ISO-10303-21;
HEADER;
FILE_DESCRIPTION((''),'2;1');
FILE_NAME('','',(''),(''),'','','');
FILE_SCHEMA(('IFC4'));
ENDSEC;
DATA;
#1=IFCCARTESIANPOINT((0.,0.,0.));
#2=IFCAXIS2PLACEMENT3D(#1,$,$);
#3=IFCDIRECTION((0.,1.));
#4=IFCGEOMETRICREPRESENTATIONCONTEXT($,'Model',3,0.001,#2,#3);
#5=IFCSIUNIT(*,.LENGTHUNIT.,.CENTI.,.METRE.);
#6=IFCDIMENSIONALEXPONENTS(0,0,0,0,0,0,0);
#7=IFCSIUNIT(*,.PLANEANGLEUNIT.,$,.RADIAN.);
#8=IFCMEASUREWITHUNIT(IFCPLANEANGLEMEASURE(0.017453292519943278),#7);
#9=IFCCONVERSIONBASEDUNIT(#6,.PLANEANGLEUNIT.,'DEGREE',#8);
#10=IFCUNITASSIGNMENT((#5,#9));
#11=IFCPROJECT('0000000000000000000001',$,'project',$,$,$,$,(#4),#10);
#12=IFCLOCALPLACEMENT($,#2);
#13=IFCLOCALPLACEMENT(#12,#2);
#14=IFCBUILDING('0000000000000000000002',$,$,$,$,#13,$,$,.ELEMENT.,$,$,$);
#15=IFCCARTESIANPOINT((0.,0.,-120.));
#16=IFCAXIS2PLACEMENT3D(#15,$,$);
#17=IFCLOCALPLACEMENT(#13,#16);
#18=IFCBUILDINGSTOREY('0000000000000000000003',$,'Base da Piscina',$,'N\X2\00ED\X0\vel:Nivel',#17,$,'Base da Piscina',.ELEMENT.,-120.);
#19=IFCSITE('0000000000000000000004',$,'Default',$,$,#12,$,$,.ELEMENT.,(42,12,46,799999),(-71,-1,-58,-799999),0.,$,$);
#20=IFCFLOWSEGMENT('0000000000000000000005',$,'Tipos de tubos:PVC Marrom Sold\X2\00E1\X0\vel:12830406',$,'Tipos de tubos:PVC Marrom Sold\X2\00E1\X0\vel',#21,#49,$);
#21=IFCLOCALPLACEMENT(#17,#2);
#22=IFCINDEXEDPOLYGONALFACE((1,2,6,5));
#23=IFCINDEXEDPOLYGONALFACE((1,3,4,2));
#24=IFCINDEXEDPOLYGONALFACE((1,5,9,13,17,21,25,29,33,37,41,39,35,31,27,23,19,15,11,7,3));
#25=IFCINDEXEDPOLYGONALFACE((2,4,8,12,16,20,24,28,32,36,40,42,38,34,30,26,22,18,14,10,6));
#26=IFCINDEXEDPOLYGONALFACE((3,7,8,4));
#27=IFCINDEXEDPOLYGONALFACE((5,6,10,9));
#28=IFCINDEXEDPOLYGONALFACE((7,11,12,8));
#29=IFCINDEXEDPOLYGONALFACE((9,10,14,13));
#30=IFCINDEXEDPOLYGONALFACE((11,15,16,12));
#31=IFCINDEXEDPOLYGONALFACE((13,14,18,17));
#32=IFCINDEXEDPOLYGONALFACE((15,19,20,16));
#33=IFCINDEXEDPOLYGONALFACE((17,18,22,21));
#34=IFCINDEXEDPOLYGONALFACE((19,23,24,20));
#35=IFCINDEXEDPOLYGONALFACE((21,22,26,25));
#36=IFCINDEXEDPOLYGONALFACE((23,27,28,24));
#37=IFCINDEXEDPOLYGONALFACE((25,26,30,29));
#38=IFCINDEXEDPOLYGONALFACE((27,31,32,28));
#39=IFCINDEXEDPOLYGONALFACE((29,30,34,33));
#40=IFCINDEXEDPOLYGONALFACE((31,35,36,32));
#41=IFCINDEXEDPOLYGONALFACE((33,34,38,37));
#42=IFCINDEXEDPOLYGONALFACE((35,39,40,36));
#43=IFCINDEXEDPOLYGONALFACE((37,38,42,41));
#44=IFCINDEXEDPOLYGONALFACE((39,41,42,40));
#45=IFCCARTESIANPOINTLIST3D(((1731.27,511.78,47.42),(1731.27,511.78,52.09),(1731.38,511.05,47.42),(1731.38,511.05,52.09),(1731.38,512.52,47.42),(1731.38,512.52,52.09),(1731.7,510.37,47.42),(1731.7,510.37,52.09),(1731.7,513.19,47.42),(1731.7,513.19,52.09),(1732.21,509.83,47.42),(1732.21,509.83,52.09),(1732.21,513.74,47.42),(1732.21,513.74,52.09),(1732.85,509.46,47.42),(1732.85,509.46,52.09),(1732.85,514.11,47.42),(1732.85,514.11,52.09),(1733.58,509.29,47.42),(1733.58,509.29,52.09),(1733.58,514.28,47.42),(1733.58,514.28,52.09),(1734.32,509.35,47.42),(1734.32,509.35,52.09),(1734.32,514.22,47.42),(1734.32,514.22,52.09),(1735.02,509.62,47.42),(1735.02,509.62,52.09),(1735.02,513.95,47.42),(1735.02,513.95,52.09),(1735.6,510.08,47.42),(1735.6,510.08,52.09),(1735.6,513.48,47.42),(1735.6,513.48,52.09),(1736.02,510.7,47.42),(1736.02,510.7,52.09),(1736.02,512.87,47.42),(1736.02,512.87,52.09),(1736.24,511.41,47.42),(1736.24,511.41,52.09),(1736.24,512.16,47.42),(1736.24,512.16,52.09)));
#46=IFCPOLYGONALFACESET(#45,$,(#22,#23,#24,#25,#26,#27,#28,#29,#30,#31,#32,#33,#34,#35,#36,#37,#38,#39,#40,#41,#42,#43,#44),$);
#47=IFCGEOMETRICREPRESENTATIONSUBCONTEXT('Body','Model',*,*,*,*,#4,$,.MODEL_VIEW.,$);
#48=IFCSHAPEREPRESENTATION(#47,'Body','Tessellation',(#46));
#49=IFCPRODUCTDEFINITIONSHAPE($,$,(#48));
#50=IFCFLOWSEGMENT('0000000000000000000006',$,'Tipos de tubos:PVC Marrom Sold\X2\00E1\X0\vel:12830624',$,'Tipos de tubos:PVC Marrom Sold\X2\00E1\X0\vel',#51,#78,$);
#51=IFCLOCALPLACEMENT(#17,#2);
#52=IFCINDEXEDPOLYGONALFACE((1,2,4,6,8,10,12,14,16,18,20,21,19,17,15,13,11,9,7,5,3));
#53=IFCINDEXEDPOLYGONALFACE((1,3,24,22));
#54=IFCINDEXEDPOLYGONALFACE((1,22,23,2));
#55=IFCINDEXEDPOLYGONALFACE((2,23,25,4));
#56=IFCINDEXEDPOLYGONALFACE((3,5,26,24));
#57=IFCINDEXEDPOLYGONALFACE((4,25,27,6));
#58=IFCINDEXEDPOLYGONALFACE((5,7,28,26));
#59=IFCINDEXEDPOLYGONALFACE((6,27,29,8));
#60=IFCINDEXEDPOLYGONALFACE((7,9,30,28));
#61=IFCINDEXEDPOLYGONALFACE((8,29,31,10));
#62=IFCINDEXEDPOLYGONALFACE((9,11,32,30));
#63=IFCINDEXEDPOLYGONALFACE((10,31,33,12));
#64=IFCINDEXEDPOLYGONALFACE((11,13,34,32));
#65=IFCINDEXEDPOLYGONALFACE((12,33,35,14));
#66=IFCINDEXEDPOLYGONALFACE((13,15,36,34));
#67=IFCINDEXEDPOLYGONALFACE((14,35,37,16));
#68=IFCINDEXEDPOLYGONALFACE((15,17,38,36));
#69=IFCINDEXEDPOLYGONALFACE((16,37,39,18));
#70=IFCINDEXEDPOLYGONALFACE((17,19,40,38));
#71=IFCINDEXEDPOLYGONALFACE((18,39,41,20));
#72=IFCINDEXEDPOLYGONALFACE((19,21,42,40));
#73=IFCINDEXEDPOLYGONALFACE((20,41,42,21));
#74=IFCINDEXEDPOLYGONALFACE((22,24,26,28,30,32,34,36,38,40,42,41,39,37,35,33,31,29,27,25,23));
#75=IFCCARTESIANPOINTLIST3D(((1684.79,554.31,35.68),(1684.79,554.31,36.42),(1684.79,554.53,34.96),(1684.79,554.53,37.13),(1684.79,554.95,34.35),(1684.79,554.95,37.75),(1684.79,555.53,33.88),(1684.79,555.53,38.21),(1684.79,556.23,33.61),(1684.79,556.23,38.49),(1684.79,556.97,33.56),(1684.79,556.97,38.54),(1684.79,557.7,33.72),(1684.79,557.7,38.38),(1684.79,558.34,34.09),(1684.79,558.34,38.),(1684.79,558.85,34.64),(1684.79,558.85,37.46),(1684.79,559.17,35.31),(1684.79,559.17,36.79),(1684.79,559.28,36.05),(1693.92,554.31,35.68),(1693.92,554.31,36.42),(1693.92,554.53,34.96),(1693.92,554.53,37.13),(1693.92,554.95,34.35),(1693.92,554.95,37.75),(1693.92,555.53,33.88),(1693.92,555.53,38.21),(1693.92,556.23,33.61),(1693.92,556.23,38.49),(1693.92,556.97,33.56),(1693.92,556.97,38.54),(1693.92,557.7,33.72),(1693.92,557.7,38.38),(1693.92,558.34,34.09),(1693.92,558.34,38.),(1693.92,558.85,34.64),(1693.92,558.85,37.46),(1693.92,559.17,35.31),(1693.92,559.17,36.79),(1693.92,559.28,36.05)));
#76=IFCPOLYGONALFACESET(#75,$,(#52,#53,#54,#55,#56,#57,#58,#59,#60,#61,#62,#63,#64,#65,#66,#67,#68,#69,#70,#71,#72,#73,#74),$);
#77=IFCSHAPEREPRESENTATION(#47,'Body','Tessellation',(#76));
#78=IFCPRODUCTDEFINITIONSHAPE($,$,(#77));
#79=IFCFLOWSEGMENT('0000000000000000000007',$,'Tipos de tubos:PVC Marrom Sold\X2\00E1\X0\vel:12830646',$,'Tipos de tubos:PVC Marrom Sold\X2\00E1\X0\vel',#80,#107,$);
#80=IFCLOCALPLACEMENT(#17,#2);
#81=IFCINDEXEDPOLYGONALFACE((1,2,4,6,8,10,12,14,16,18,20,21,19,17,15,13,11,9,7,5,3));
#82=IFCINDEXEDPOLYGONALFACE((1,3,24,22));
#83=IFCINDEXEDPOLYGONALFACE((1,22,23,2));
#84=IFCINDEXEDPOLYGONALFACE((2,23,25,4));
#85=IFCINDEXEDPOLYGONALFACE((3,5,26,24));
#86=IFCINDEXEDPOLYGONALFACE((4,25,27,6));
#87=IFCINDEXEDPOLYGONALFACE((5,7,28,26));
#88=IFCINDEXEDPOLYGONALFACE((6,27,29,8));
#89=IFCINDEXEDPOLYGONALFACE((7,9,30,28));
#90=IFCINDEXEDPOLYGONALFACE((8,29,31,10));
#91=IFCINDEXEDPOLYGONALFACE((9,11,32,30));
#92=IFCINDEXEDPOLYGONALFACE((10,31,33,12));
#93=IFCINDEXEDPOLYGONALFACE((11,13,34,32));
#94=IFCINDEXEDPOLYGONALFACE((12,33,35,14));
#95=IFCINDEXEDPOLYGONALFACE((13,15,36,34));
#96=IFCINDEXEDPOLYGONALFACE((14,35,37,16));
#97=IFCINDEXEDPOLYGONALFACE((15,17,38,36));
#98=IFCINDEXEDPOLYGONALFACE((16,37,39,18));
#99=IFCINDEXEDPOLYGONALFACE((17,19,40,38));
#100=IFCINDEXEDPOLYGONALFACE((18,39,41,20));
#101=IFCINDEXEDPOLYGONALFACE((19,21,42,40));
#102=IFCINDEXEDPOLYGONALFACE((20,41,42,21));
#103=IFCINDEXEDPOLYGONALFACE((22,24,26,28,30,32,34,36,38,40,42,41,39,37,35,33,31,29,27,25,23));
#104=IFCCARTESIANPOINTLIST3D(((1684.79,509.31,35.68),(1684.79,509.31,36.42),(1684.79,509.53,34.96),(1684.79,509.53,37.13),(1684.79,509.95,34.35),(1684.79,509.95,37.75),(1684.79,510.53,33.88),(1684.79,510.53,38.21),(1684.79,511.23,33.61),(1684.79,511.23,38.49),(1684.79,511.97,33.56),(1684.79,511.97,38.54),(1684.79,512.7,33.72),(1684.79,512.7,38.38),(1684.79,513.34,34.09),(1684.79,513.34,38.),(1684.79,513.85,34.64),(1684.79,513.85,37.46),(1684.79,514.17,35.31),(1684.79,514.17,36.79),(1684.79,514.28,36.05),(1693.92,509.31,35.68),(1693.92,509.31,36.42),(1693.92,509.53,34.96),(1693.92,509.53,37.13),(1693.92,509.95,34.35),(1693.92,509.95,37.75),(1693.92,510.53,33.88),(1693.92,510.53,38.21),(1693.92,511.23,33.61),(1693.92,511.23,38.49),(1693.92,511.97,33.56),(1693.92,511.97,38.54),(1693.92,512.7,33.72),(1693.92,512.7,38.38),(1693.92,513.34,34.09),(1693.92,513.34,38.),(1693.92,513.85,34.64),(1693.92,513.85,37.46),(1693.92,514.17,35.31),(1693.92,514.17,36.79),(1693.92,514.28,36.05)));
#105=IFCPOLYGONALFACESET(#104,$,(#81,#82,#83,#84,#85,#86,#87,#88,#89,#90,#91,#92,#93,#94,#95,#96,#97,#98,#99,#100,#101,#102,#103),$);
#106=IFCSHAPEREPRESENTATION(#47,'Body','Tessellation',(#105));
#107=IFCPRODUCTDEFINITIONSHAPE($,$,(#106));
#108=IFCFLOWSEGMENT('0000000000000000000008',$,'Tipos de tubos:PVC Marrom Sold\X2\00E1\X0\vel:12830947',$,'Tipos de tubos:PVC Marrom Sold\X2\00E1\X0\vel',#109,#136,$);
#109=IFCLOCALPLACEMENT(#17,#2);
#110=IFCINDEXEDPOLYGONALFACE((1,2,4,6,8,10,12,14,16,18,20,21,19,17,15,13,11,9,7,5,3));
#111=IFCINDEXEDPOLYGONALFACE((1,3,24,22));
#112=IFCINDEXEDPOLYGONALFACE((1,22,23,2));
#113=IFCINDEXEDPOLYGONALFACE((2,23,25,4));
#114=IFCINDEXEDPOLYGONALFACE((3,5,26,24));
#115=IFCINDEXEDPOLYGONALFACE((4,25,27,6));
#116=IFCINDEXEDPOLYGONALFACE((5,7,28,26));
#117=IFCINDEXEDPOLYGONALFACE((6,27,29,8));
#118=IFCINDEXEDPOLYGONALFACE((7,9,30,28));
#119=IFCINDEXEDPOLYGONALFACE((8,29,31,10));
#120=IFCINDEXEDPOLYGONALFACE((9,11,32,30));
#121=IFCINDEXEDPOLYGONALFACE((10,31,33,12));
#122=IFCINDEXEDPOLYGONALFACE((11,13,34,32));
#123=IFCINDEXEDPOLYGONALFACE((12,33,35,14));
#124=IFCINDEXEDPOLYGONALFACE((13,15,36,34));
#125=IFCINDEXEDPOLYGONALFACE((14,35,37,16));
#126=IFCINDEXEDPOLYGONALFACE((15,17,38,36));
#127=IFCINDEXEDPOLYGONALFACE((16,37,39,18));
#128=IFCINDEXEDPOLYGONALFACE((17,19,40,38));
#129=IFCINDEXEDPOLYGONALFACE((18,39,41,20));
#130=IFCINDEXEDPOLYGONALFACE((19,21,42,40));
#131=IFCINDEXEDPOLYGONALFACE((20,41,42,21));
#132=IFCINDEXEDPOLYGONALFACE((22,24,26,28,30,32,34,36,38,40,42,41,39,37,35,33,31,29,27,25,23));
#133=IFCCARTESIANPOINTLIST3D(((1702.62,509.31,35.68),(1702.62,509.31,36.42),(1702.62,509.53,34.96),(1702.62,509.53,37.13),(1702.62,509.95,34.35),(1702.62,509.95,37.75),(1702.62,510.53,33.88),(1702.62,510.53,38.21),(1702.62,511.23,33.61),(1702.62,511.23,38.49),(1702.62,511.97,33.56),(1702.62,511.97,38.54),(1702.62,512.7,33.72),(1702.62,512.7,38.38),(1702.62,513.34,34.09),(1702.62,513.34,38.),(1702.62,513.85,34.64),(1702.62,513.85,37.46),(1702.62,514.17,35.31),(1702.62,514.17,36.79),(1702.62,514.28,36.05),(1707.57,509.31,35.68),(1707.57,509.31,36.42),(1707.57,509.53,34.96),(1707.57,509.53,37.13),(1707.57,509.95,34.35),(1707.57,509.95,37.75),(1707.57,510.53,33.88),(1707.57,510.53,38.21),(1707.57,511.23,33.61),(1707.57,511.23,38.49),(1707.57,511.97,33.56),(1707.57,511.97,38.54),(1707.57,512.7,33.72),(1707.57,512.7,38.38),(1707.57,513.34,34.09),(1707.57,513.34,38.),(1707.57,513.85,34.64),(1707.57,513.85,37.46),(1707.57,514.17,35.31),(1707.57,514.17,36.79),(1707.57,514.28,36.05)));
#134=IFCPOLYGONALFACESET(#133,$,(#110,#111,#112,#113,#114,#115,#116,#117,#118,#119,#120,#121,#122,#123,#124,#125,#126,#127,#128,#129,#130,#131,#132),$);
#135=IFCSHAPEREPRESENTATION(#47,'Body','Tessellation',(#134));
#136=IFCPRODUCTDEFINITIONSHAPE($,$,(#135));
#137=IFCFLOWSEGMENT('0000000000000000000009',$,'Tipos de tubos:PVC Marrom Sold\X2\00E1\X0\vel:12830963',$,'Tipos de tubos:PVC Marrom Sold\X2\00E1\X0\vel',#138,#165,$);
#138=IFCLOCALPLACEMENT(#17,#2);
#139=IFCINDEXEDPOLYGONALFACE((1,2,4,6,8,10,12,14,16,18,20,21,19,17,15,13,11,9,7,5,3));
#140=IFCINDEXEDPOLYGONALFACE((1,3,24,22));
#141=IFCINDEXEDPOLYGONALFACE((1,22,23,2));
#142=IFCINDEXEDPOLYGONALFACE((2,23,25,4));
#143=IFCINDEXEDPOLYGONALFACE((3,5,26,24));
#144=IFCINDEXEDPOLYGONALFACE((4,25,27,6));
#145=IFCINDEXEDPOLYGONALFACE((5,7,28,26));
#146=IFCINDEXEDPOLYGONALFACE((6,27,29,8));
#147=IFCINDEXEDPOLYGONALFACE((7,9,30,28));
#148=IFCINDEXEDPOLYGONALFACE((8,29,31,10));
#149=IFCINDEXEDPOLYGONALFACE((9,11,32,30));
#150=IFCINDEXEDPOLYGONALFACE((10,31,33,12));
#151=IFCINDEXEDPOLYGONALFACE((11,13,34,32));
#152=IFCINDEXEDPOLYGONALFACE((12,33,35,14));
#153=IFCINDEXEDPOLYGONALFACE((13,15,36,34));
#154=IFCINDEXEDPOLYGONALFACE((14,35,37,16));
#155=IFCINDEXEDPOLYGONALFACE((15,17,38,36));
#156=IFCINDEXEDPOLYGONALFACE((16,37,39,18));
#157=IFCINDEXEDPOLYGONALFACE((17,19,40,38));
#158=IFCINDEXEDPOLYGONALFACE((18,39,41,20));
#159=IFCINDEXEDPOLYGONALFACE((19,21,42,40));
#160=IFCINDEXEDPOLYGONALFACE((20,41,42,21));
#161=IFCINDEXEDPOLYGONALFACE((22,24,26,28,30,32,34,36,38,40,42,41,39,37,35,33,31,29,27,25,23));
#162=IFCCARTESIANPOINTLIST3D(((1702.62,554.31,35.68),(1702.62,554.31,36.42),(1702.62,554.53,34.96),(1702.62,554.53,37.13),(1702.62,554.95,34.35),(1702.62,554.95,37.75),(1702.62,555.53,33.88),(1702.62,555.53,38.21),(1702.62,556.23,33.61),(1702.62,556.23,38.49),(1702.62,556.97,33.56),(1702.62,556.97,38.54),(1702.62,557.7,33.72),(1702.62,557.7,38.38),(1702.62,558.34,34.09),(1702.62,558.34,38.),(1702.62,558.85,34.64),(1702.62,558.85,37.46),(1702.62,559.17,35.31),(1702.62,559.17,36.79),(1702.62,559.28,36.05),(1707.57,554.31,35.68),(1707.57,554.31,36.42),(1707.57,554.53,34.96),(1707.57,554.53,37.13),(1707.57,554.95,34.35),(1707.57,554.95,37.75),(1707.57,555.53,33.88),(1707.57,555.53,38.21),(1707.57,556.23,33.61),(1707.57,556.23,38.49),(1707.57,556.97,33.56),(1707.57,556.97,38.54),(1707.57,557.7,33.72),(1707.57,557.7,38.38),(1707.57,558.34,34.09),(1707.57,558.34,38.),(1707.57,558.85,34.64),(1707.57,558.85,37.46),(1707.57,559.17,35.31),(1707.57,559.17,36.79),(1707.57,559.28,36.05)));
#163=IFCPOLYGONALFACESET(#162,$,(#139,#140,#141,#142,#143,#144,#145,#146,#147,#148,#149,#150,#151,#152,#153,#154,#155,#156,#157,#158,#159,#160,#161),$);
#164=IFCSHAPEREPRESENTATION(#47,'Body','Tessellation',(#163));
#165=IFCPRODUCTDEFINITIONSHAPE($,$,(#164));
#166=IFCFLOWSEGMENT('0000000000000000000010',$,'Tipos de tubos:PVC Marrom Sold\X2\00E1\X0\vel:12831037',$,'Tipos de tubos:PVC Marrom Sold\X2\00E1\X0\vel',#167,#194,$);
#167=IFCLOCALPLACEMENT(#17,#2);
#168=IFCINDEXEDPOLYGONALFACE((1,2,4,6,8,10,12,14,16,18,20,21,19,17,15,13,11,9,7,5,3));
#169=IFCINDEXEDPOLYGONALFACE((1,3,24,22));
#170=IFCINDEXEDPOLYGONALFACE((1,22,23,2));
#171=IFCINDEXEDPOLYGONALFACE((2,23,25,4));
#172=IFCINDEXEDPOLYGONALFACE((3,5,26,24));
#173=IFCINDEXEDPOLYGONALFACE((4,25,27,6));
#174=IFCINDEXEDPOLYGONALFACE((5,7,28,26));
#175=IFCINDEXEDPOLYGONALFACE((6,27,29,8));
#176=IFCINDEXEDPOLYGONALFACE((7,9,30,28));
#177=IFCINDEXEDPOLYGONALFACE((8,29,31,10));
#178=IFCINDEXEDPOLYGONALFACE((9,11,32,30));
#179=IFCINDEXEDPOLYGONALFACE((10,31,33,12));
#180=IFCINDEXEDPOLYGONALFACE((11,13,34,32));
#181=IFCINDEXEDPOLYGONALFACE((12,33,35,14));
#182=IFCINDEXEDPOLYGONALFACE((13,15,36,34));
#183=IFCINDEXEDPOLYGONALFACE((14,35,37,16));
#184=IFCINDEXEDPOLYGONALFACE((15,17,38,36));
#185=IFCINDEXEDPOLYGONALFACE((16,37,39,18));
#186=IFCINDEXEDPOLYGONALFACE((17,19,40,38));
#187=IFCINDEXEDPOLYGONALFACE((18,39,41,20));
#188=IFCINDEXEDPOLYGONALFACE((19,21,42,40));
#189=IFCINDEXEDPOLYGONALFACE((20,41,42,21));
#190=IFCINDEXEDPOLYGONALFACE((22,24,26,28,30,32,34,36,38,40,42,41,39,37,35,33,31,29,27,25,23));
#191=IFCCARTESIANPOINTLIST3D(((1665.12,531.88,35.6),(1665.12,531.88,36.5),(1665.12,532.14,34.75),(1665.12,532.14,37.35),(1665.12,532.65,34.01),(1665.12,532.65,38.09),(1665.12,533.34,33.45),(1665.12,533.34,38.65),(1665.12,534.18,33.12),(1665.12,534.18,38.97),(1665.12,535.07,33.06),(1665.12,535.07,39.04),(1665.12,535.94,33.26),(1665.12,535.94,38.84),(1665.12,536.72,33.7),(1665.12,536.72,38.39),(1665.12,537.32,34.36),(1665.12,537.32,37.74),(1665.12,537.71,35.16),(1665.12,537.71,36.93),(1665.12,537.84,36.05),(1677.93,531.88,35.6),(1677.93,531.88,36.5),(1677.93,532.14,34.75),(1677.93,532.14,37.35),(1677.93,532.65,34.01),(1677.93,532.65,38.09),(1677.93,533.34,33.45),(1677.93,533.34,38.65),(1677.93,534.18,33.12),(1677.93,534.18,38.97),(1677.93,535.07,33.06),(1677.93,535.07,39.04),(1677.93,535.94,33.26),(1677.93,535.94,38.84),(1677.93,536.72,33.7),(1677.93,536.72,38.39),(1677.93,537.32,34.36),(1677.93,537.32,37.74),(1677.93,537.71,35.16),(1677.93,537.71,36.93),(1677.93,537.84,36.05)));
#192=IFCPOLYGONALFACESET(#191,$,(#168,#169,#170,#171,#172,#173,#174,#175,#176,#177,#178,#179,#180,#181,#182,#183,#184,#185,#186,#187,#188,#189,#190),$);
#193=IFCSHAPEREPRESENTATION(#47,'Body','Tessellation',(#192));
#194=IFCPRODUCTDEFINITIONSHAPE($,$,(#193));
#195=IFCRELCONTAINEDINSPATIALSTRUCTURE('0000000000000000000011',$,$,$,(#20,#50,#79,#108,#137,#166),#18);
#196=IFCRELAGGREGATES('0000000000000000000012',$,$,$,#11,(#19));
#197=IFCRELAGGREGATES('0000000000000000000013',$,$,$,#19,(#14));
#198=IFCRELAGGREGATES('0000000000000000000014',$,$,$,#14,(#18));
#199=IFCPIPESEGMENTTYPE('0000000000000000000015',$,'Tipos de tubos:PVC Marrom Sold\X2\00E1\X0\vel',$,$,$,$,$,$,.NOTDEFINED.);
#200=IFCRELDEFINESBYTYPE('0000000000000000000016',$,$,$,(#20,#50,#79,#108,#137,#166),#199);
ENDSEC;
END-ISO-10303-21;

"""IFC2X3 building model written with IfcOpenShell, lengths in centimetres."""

from ifc_helpers import new_model, entity, si_unit, converted_unit, direction, frame, frame_2d, origin, origin_2d_with_axis, place, context, subcontext, project, spatial, circle, extrude, type_object, element, save


model = new_model("IFC2X3")

# Units and contexts
model_context = context("Model", 3, precision=0.001, world=origin(), true_north=direction((0.0, 1.0)))
body_context = subcontext(model_context, "Body", "Model", "MODEL_VIEW")
ifc_project = project(units=[si_unit("LENGTHUNIT", "METRE", prefix="CENTI"), converted_unit("PLANEANGLEUNIT", "DEGREE", entity("IfcPlaneAngleMeasure", 0.017453292519943278), si_unit("PLANEANGLEUNIT", "RADIAN"), dimensions=[0, 0, 0, 0, 0, 0, 0])], contexts=[model_context])

# Site, building, storey
site_placement = place(None, origin())
site = spatial("IfcSite", under=ifc_project, at=site_placement, Name="Default", CompositionType="ELEMENT", RefLatitude=(42, 12, 46, 799999), RefLongitude=(-71, -1, -58, -799999), RefElevation=0.0)
building_placement = place(site_placement, origin())
building = spatial("IfcBuilding", under=site, at=building_placement, CompositionType="ELEMENT")
storey_placement = place(building_placement, frame((0.0, 0.0, -120.0)))
storey = spatial("IfcBuildingStorey", under=building, at=storey_placement, Name="Base da Piscina", ObjectType="Nível:Nivel", LongName="Base da Piscina", CompositionType="ELEMENT", Elevation=-120.0)

# Flow segments
pipe_segment_type = type_object("IfcPipeSegmentType", Name="Tipos de tubos:PVC Marrom Soldável", PredefinedType="NOTDEFINED")
flow_segment_1_placement = place(storey_placement, origin())
element("IfcFlowSegment", 1, at=flow_segment_1_placement, inside=storey, type_object=pipe_segment_type, Name="Tipos de tubos:PVC Marrom Soldável:12830406", ObjectType="Tipos de tubos:PVC Marrom Soldável", context=body_context, shape_type="SweptSolid", body=[
    extrude(circle(Radius=2.5, at=origin_2d_with_axis()), frame((1733.77, 511.78, 47.42), z_axis=(0.0, 0.0, 1.0), x_axis=(-1.0, 0.0, 0.0)), (0.0, 0.0, 1.0), 4.67),
])
flow_segment_2_placement = place(storey_placement, origin())
element("IfcFlowSegment", 2, at=flow_segment_2_placement, inside=storey, type_object=pipe_segment_type, Name="Tipos de tubos:PVC Marrom Soldável:12830624", ObjectType="Tipos de tubos:PVC Marrom Soldável", context=body_context, shape_type="SweptSolid", body=[
    extrude(circle(Radius=2.5, at=origin_2d_with_axis()), frame((1684.79, 556.78, 36.05), z_axis=(1.0, 0.0, 0.0), x_axis=(0.0, 1.0, 0.0)), (0.0, 0.0, 1.0), 9.14),
])
flow_segment_3_placement = place(storey_placement, origin())
element("IfcFlowSegment", 3, at=flow_segment_3_placement, inside=storey, type_object=pipe_segment_type, Name="Tipos de tubos:PVC Marrom Soldável:12830646", ObjectType="Tipos de tubos:PVC Marrom Soldável", context=body_context, shape_type="SweptSolid", body=[
    extrude(circle(Radius=2.5, at=frame_2d((0.0, 0.0), x_axis=(1.0, 0.0))), frame((1684.79, 511.78, 36.05), z_axis=(1.0, 0.0, 0.0), x_axis=(0.0, 1.0, 0.0)), (0.0, 0.0, 1.0), 9.14),
])
flow_segment_4_placement = place(storey_placement, origin())
element("IfcFlowSegment", 4, at=flow_segment_4_placement, inside=storey, type_object=pipe_segment_type, Name="Tipos de tubos:PVC Marrom Soldável:12830947", ObjectType="Tipos de tubos:PVC Marrom Soldável", context=body_context, shape_type="SweptSolid", body=[
    extrude(circle(Radius=2.5, at=frame_2d((0.0, 0.0), x_axis=(1.0, 0.0))), frame((1702.62, 511.78, 36.05), z_axis=(1.0, 0.0, 0.0), x_axis=(0.0, 1.0, 0.0)), (0.0, 0.0, 1.0), 4.94),
])
flow_segment_5_placement = place(storey_placement, origin())
element("IfcFlowSegment", 5, at=flow_segment_5_placement, inside=storey, type_object=pipe_segment_type, Name="Tipos de tubos:PVC Marrom Soldável:12830963", ObjectType="Tipos de tubos:PVC Marrom Soldável", context=body_context, shape_type="SweptSolid", body=[
    extrude(circle(Radius=2.5, at=origin_2d_with_axis()), frame((1702.62, 556.78, 36.05), z_axis=(1.0, 0.0, 0.0), x_axis=(0.0, 1.0, 0.0)), (0.0, 0.0, 1.0), 4.94),
])
flow_segment_6_placement = place(storey_placement, origin())
element("IfcFlowSegment", 6, at=flow_segment_6_placement, inside=storey, type_object=pipe_segment_type, Name="Tipos de tubos:PVC Marrom Soldável:12831037", ObjectType="Tipos de tubos:PVC Marrom Soldável", context=body_context, shape_type="SweptSolid", body=[
    extrude(circle(Radius=3.0, at=origin_2d_with_axis()), frame((1665.12, 534.84, 36.05), z_axis=(1.0, 0.0, 0.0), x_axis=(0.0, 1.0, 0.0)), (0.0, 0.0, 1.0), 12.81),
])

save(model, "model.ifc")
